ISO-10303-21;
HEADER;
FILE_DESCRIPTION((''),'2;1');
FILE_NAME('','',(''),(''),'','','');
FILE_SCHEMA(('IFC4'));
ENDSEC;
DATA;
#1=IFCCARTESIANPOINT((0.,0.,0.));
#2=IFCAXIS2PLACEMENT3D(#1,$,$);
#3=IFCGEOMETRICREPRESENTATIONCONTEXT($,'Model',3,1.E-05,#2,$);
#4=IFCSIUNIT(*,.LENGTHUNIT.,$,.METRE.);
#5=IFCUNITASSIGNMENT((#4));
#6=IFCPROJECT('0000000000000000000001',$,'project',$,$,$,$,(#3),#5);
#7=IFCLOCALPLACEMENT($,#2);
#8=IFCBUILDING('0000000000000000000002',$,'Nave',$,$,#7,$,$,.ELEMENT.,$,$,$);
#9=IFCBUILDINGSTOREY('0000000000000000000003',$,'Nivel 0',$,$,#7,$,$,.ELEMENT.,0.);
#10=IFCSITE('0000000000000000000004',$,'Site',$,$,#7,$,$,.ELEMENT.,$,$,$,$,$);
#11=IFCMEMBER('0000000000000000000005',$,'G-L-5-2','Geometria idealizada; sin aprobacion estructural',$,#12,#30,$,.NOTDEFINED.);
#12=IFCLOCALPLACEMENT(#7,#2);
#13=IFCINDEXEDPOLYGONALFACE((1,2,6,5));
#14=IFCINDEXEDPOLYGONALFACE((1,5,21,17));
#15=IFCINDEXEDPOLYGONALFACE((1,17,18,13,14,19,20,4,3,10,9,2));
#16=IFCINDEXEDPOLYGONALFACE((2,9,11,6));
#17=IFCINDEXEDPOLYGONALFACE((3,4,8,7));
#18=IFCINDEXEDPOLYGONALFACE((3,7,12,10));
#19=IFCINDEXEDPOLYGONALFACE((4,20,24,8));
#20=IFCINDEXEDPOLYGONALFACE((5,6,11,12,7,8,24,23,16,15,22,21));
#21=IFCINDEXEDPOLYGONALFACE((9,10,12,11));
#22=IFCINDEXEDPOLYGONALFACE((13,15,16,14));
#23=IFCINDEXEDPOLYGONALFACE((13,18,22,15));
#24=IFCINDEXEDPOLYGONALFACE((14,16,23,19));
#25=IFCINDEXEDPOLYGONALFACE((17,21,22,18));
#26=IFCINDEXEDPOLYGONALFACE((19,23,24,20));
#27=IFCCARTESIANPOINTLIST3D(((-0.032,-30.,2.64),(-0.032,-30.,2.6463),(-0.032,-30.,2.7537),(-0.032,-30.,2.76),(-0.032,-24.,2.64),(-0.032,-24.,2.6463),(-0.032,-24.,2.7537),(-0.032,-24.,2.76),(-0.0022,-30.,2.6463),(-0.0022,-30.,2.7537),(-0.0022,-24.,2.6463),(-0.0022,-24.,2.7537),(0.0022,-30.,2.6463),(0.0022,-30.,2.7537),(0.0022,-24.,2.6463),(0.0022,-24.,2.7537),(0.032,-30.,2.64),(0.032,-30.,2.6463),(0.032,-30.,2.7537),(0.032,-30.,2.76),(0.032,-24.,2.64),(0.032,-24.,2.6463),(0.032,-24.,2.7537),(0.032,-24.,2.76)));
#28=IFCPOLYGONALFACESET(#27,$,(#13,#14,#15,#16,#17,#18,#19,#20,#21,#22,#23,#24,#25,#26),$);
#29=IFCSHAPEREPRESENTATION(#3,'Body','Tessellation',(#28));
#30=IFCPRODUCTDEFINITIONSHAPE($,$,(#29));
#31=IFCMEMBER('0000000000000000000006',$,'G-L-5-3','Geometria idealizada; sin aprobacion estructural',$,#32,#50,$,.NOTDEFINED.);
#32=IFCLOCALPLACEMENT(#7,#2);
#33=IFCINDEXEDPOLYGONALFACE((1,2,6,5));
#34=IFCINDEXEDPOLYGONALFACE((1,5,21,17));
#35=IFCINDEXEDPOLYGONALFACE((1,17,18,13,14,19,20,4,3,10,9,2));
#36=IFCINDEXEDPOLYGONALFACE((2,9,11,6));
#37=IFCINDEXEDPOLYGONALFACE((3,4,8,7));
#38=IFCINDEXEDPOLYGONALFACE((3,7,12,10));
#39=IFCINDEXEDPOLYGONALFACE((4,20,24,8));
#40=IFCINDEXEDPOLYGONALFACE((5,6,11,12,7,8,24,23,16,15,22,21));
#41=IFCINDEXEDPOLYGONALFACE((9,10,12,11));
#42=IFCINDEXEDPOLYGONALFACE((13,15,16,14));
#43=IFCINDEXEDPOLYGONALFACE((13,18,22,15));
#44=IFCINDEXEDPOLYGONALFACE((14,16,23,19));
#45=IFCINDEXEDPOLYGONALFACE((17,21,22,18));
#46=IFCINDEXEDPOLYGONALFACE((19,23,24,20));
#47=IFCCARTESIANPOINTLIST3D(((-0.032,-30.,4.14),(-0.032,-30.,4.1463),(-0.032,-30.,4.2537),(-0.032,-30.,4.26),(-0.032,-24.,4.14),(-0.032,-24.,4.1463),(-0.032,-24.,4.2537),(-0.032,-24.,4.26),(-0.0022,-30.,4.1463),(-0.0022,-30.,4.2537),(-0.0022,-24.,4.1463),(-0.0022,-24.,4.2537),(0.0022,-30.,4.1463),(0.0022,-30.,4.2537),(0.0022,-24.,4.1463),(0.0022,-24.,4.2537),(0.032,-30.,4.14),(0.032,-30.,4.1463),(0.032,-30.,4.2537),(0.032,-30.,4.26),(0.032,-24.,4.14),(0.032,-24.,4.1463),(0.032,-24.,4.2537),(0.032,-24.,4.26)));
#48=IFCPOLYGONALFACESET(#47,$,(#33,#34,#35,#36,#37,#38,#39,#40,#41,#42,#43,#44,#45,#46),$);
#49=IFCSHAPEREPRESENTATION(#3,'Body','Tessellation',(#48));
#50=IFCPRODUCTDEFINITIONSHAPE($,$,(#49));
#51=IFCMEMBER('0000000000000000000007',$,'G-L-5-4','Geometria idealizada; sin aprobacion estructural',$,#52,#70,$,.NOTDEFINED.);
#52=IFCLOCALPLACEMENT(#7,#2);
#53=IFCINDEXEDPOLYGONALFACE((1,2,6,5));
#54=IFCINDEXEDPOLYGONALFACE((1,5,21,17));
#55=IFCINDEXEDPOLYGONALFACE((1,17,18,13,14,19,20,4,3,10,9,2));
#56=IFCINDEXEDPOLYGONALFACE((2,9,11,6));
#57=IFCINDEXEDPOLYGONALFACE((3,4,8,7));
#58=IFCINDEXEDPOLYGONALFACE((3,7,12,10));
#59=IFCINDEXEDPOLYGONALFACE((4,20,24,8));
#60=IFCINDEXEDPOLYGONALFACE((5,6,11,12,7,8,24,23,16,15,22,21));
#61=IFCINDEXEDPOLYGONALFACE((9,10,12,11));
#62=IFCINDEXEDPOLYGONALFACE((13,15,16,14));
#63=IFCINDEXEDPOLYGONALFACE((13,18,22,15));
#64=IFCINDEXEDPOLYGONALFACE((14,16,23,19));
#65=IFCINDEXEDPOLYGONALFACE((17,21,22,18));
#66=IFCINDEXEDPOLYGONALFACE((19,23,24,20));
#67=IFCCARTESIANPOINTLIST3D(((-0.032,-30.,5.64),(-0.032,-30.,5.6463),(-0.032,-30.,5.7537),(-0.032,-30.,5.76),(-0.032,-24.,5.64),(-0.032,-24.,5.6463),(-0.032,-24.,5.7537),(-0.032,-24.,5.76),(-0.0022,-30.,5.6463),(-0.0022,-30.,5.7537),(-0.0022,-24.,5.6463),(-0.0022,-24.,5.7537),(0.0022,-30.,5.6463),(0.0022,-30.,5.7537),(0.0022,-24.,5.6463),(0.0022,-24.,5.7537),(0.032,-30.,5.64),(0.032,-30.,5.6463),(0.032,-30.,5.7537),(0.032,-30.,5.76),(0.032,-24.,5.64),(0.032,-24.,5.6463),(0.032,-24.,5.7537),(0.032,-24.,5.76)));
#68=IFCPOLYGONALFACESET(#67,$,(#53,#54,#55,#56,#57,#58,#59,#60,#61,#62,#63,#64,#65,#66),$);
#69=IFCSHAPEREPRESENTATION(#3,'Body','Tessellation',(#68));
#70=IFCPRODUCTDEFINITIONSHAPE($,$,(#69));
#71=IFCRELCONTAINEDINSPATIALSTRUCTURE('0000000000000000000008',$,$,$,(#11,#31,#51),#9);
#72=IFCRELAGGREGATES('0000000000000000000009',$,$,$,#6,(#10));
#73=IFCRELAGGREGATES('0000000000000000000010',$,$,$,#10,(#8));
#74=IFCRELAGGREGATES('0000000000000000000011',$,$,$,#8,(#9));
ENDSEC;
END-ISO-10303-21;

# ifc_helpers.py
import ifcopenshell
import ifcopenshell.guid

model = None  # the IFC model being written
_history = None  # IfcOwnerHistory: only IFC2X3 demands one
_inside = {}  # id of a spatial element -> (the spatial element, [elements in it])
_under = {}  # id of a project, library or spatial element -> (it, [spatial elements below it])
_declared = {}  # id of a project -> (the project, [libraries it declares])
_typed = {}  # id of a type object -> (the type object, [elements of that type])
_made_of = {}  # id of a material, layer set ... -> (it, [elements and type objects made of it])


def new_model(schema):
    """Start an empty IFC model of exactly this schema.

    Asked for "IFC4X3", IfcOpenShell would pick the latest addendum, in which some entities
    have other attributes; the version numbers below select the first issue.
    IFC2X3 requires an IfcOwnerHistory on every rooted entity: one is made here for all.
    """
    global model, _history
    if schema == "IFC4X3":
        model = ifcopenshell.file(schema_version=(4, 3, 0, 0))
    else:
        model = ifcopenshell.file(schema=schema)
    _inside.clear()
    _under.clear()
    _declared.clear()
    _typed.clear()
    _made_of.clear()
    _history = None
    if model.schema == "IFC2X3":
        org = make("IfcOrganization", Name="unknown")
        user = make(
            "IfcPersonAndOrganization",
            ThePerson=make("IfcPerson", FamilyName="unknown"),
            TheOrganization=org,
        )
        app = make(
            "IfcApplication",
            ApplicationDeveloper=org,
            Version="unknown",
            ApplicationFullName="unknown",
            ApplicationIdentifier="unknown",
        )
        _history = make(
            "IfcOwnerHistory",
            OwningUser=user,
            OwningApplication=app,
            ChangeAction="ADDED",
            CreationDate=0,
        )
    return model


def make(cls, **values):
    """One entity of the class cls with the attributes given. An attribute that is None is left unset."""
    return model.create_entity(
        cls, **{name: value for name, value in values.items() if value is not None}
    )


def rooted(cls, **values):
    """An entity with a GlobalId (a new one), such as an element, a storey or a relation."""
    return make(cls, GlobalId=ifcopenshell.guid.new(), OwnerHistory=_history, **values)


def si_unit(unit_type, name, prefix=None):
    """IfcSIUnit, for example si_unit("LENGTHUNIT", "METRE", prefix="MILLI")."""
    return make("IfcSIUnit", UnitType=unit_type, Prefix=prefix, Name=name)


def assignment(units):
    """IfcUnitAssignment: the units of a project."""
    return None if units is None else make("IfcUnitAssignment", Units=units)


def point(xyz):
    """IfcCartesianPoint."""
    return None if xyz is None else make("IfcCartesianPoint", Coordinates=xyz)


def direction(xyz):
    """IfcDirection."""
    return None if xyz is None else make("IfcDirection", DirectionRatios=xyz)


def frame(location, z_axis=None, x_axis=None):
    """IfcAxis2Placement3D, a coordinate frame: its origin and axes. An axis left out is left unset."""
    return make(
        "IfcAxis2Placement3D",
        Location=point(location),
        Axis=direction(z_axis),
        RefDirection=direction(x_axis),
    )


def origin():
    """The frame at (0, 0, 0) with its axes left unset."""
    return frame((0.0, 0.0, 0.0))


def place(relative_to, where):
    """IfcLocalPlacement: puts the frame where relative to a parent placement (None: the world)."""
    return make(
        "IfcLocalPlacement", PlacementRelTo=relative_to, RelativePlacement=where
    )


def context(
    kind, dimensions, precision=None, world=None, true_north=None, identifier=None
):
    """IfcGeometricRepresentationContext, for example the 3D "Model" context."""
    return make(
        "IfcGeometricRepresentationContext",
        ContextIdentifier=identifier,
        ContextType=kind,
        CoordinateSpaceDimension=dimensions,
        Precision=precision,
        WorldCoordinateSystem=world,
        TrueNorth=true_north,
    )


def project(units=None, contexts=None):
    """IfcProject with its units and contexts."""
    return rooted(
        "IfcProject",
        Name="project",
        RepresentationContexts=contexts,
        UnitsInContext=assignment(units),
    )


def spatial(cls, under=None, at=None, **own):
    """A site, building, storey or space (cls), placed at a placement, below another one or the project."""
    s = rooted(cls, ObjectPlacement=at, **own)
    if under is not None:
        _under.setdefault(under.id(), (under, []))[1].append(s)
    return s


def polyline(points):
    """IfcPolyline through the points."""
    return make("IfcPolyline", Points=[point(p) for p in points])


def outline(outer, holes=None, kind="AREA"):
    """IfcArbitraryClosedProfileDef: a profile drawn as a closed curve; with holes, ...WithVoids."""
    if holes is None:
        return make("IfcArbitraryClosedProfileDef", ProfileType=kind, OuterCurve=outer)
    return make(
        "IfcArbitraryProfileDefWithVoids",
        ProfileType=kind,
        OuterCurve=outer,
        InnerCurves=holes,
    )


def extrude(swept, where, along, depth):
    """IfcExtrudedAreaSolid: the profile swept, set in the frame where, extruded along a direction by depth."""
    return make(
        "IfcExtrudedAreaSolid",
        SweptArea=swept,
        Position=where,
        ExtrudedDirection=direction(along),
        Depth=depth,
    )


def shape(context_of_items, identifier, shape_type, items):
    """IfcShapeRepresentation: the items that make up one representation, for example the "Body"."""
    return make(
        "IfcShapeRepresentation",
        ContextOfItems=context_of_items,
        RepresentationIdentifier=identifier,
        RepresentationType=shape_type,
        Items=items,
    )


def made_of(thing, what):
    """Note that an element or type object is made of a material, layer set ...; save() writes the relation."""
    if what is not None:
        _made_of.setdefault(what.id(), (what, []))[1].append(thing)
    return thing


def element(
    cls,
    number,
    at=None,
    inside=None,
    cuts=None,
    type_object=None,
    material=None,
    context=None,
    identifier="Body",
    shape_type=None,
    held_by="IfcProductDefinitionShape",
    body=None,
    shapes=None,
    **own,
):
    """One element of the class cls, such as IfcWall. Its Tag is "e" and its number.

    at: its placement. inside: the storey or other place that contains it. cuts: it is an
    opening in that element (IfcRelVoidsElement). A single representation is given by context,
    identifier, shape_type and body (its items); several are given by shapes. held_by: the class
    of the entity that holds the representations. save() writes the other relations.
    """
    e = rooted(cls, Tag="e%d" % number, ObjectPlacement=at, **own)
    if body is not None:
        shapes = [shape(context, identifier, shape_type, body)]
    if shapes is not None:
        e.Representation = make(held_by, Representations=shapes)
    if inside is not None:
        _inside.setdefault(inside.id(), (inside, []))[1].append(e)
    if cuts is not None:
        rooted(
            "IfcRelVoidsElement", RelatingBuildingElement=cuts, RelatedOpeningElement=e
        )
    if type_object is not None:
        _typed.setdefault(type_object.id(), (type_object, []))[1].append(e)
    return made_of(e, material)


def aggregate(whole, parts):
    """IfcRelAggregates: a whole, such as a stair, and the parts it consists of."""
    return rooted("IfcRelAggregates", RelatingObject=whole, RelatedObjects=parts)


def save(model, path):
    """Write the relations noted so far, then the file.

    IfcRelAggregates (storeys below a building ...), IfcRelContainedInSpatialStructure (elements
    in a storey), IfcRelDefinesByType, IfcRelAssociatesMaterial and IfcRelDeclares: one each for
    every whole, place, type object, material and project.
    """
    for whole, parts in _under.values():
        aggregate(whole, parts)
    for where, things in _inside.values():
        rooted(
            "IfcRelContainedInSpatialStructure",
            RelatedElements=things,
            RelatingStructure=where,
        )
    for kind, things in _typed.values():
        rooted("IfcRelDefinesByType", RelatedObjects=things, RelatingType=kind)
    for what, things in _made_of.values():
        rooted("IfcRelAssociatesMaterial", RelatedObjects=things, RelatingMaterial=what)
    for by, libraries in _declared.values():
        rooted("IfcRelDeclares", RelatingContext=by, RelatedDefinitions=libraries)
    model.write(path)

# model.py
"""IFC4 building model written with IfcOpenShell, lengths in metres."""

from ifc_helpers import new_model, si_unit, frame, origin, place, context, project, spatial, polyline, outline, extrude, element, save


model = new_model("IFC4")

# Units and contexts
model_context = context("Model", 3, precision=1e-05, world=origin())
ifc_project = project(units=[si_unit("LENGTHUNIT", "METRE")], contexts=[model_context])

# Site, building, storey
placement = place(None, origin())
site = spatial("IfcSite", under=ifc_project, at=placement, Name="Site", CompositionType="ELEMENT")
building = spatial("IfcBuilding", under=site, at=placement, Name="Nave", CompositionType="ELEMENT")
storey = spatial("IfcBuildingStorey", under=building, at=placement, Name="Nivel 0", CompositionType="ELEMENT", Elevation=0.0)

# Members
for number, where, z_axis, x_axis, name in (
    (1, (0.0, -24.0, 2.7), (0.0, -1.0, 0.0), (1.0, 0.0, 0.0), "G-L-5-2"),
    (2, (0.0, -24.0, 4.2), (0.0, -1.0, 0.0), (1.0, 0.0, 0.0), "G-L-5-3"),
    (3, (0.0, -24.0, 5.7), (0.0, -1.0, 0.0), (1.0, 0.0, 0.0), "G-L-5-4"),
):
    element("IfcMember", number, at=place(placement, frame(where, z_axis=z_axis, x_axis=x_axis)), inside=storey, Name=name, Description="Geometria idealizada; sin aprobacion estructural", PredefinedType="NOTDEFINED", context=model_context, shape_type="SweptSolid", body=[
        extrude(outline(polyline([(-0.032, -0.06), (0.032, -0.06), (0.032, -0.0537), (0.0022, -0.0537), (0.0022, 0.0537), (0.032, 0.0537), (0.032, 0.06), (-0.032, 0.06), (-0.032, 0.0537), (-0.0022, 0.0537), (-0.0022, -0.0537), (-0.032, -0.0537), (-0.032, -0.06)])), origin(), (0.0, 0.0, 1.0), 6.0),
    ])

save(model, "model.ifc")
